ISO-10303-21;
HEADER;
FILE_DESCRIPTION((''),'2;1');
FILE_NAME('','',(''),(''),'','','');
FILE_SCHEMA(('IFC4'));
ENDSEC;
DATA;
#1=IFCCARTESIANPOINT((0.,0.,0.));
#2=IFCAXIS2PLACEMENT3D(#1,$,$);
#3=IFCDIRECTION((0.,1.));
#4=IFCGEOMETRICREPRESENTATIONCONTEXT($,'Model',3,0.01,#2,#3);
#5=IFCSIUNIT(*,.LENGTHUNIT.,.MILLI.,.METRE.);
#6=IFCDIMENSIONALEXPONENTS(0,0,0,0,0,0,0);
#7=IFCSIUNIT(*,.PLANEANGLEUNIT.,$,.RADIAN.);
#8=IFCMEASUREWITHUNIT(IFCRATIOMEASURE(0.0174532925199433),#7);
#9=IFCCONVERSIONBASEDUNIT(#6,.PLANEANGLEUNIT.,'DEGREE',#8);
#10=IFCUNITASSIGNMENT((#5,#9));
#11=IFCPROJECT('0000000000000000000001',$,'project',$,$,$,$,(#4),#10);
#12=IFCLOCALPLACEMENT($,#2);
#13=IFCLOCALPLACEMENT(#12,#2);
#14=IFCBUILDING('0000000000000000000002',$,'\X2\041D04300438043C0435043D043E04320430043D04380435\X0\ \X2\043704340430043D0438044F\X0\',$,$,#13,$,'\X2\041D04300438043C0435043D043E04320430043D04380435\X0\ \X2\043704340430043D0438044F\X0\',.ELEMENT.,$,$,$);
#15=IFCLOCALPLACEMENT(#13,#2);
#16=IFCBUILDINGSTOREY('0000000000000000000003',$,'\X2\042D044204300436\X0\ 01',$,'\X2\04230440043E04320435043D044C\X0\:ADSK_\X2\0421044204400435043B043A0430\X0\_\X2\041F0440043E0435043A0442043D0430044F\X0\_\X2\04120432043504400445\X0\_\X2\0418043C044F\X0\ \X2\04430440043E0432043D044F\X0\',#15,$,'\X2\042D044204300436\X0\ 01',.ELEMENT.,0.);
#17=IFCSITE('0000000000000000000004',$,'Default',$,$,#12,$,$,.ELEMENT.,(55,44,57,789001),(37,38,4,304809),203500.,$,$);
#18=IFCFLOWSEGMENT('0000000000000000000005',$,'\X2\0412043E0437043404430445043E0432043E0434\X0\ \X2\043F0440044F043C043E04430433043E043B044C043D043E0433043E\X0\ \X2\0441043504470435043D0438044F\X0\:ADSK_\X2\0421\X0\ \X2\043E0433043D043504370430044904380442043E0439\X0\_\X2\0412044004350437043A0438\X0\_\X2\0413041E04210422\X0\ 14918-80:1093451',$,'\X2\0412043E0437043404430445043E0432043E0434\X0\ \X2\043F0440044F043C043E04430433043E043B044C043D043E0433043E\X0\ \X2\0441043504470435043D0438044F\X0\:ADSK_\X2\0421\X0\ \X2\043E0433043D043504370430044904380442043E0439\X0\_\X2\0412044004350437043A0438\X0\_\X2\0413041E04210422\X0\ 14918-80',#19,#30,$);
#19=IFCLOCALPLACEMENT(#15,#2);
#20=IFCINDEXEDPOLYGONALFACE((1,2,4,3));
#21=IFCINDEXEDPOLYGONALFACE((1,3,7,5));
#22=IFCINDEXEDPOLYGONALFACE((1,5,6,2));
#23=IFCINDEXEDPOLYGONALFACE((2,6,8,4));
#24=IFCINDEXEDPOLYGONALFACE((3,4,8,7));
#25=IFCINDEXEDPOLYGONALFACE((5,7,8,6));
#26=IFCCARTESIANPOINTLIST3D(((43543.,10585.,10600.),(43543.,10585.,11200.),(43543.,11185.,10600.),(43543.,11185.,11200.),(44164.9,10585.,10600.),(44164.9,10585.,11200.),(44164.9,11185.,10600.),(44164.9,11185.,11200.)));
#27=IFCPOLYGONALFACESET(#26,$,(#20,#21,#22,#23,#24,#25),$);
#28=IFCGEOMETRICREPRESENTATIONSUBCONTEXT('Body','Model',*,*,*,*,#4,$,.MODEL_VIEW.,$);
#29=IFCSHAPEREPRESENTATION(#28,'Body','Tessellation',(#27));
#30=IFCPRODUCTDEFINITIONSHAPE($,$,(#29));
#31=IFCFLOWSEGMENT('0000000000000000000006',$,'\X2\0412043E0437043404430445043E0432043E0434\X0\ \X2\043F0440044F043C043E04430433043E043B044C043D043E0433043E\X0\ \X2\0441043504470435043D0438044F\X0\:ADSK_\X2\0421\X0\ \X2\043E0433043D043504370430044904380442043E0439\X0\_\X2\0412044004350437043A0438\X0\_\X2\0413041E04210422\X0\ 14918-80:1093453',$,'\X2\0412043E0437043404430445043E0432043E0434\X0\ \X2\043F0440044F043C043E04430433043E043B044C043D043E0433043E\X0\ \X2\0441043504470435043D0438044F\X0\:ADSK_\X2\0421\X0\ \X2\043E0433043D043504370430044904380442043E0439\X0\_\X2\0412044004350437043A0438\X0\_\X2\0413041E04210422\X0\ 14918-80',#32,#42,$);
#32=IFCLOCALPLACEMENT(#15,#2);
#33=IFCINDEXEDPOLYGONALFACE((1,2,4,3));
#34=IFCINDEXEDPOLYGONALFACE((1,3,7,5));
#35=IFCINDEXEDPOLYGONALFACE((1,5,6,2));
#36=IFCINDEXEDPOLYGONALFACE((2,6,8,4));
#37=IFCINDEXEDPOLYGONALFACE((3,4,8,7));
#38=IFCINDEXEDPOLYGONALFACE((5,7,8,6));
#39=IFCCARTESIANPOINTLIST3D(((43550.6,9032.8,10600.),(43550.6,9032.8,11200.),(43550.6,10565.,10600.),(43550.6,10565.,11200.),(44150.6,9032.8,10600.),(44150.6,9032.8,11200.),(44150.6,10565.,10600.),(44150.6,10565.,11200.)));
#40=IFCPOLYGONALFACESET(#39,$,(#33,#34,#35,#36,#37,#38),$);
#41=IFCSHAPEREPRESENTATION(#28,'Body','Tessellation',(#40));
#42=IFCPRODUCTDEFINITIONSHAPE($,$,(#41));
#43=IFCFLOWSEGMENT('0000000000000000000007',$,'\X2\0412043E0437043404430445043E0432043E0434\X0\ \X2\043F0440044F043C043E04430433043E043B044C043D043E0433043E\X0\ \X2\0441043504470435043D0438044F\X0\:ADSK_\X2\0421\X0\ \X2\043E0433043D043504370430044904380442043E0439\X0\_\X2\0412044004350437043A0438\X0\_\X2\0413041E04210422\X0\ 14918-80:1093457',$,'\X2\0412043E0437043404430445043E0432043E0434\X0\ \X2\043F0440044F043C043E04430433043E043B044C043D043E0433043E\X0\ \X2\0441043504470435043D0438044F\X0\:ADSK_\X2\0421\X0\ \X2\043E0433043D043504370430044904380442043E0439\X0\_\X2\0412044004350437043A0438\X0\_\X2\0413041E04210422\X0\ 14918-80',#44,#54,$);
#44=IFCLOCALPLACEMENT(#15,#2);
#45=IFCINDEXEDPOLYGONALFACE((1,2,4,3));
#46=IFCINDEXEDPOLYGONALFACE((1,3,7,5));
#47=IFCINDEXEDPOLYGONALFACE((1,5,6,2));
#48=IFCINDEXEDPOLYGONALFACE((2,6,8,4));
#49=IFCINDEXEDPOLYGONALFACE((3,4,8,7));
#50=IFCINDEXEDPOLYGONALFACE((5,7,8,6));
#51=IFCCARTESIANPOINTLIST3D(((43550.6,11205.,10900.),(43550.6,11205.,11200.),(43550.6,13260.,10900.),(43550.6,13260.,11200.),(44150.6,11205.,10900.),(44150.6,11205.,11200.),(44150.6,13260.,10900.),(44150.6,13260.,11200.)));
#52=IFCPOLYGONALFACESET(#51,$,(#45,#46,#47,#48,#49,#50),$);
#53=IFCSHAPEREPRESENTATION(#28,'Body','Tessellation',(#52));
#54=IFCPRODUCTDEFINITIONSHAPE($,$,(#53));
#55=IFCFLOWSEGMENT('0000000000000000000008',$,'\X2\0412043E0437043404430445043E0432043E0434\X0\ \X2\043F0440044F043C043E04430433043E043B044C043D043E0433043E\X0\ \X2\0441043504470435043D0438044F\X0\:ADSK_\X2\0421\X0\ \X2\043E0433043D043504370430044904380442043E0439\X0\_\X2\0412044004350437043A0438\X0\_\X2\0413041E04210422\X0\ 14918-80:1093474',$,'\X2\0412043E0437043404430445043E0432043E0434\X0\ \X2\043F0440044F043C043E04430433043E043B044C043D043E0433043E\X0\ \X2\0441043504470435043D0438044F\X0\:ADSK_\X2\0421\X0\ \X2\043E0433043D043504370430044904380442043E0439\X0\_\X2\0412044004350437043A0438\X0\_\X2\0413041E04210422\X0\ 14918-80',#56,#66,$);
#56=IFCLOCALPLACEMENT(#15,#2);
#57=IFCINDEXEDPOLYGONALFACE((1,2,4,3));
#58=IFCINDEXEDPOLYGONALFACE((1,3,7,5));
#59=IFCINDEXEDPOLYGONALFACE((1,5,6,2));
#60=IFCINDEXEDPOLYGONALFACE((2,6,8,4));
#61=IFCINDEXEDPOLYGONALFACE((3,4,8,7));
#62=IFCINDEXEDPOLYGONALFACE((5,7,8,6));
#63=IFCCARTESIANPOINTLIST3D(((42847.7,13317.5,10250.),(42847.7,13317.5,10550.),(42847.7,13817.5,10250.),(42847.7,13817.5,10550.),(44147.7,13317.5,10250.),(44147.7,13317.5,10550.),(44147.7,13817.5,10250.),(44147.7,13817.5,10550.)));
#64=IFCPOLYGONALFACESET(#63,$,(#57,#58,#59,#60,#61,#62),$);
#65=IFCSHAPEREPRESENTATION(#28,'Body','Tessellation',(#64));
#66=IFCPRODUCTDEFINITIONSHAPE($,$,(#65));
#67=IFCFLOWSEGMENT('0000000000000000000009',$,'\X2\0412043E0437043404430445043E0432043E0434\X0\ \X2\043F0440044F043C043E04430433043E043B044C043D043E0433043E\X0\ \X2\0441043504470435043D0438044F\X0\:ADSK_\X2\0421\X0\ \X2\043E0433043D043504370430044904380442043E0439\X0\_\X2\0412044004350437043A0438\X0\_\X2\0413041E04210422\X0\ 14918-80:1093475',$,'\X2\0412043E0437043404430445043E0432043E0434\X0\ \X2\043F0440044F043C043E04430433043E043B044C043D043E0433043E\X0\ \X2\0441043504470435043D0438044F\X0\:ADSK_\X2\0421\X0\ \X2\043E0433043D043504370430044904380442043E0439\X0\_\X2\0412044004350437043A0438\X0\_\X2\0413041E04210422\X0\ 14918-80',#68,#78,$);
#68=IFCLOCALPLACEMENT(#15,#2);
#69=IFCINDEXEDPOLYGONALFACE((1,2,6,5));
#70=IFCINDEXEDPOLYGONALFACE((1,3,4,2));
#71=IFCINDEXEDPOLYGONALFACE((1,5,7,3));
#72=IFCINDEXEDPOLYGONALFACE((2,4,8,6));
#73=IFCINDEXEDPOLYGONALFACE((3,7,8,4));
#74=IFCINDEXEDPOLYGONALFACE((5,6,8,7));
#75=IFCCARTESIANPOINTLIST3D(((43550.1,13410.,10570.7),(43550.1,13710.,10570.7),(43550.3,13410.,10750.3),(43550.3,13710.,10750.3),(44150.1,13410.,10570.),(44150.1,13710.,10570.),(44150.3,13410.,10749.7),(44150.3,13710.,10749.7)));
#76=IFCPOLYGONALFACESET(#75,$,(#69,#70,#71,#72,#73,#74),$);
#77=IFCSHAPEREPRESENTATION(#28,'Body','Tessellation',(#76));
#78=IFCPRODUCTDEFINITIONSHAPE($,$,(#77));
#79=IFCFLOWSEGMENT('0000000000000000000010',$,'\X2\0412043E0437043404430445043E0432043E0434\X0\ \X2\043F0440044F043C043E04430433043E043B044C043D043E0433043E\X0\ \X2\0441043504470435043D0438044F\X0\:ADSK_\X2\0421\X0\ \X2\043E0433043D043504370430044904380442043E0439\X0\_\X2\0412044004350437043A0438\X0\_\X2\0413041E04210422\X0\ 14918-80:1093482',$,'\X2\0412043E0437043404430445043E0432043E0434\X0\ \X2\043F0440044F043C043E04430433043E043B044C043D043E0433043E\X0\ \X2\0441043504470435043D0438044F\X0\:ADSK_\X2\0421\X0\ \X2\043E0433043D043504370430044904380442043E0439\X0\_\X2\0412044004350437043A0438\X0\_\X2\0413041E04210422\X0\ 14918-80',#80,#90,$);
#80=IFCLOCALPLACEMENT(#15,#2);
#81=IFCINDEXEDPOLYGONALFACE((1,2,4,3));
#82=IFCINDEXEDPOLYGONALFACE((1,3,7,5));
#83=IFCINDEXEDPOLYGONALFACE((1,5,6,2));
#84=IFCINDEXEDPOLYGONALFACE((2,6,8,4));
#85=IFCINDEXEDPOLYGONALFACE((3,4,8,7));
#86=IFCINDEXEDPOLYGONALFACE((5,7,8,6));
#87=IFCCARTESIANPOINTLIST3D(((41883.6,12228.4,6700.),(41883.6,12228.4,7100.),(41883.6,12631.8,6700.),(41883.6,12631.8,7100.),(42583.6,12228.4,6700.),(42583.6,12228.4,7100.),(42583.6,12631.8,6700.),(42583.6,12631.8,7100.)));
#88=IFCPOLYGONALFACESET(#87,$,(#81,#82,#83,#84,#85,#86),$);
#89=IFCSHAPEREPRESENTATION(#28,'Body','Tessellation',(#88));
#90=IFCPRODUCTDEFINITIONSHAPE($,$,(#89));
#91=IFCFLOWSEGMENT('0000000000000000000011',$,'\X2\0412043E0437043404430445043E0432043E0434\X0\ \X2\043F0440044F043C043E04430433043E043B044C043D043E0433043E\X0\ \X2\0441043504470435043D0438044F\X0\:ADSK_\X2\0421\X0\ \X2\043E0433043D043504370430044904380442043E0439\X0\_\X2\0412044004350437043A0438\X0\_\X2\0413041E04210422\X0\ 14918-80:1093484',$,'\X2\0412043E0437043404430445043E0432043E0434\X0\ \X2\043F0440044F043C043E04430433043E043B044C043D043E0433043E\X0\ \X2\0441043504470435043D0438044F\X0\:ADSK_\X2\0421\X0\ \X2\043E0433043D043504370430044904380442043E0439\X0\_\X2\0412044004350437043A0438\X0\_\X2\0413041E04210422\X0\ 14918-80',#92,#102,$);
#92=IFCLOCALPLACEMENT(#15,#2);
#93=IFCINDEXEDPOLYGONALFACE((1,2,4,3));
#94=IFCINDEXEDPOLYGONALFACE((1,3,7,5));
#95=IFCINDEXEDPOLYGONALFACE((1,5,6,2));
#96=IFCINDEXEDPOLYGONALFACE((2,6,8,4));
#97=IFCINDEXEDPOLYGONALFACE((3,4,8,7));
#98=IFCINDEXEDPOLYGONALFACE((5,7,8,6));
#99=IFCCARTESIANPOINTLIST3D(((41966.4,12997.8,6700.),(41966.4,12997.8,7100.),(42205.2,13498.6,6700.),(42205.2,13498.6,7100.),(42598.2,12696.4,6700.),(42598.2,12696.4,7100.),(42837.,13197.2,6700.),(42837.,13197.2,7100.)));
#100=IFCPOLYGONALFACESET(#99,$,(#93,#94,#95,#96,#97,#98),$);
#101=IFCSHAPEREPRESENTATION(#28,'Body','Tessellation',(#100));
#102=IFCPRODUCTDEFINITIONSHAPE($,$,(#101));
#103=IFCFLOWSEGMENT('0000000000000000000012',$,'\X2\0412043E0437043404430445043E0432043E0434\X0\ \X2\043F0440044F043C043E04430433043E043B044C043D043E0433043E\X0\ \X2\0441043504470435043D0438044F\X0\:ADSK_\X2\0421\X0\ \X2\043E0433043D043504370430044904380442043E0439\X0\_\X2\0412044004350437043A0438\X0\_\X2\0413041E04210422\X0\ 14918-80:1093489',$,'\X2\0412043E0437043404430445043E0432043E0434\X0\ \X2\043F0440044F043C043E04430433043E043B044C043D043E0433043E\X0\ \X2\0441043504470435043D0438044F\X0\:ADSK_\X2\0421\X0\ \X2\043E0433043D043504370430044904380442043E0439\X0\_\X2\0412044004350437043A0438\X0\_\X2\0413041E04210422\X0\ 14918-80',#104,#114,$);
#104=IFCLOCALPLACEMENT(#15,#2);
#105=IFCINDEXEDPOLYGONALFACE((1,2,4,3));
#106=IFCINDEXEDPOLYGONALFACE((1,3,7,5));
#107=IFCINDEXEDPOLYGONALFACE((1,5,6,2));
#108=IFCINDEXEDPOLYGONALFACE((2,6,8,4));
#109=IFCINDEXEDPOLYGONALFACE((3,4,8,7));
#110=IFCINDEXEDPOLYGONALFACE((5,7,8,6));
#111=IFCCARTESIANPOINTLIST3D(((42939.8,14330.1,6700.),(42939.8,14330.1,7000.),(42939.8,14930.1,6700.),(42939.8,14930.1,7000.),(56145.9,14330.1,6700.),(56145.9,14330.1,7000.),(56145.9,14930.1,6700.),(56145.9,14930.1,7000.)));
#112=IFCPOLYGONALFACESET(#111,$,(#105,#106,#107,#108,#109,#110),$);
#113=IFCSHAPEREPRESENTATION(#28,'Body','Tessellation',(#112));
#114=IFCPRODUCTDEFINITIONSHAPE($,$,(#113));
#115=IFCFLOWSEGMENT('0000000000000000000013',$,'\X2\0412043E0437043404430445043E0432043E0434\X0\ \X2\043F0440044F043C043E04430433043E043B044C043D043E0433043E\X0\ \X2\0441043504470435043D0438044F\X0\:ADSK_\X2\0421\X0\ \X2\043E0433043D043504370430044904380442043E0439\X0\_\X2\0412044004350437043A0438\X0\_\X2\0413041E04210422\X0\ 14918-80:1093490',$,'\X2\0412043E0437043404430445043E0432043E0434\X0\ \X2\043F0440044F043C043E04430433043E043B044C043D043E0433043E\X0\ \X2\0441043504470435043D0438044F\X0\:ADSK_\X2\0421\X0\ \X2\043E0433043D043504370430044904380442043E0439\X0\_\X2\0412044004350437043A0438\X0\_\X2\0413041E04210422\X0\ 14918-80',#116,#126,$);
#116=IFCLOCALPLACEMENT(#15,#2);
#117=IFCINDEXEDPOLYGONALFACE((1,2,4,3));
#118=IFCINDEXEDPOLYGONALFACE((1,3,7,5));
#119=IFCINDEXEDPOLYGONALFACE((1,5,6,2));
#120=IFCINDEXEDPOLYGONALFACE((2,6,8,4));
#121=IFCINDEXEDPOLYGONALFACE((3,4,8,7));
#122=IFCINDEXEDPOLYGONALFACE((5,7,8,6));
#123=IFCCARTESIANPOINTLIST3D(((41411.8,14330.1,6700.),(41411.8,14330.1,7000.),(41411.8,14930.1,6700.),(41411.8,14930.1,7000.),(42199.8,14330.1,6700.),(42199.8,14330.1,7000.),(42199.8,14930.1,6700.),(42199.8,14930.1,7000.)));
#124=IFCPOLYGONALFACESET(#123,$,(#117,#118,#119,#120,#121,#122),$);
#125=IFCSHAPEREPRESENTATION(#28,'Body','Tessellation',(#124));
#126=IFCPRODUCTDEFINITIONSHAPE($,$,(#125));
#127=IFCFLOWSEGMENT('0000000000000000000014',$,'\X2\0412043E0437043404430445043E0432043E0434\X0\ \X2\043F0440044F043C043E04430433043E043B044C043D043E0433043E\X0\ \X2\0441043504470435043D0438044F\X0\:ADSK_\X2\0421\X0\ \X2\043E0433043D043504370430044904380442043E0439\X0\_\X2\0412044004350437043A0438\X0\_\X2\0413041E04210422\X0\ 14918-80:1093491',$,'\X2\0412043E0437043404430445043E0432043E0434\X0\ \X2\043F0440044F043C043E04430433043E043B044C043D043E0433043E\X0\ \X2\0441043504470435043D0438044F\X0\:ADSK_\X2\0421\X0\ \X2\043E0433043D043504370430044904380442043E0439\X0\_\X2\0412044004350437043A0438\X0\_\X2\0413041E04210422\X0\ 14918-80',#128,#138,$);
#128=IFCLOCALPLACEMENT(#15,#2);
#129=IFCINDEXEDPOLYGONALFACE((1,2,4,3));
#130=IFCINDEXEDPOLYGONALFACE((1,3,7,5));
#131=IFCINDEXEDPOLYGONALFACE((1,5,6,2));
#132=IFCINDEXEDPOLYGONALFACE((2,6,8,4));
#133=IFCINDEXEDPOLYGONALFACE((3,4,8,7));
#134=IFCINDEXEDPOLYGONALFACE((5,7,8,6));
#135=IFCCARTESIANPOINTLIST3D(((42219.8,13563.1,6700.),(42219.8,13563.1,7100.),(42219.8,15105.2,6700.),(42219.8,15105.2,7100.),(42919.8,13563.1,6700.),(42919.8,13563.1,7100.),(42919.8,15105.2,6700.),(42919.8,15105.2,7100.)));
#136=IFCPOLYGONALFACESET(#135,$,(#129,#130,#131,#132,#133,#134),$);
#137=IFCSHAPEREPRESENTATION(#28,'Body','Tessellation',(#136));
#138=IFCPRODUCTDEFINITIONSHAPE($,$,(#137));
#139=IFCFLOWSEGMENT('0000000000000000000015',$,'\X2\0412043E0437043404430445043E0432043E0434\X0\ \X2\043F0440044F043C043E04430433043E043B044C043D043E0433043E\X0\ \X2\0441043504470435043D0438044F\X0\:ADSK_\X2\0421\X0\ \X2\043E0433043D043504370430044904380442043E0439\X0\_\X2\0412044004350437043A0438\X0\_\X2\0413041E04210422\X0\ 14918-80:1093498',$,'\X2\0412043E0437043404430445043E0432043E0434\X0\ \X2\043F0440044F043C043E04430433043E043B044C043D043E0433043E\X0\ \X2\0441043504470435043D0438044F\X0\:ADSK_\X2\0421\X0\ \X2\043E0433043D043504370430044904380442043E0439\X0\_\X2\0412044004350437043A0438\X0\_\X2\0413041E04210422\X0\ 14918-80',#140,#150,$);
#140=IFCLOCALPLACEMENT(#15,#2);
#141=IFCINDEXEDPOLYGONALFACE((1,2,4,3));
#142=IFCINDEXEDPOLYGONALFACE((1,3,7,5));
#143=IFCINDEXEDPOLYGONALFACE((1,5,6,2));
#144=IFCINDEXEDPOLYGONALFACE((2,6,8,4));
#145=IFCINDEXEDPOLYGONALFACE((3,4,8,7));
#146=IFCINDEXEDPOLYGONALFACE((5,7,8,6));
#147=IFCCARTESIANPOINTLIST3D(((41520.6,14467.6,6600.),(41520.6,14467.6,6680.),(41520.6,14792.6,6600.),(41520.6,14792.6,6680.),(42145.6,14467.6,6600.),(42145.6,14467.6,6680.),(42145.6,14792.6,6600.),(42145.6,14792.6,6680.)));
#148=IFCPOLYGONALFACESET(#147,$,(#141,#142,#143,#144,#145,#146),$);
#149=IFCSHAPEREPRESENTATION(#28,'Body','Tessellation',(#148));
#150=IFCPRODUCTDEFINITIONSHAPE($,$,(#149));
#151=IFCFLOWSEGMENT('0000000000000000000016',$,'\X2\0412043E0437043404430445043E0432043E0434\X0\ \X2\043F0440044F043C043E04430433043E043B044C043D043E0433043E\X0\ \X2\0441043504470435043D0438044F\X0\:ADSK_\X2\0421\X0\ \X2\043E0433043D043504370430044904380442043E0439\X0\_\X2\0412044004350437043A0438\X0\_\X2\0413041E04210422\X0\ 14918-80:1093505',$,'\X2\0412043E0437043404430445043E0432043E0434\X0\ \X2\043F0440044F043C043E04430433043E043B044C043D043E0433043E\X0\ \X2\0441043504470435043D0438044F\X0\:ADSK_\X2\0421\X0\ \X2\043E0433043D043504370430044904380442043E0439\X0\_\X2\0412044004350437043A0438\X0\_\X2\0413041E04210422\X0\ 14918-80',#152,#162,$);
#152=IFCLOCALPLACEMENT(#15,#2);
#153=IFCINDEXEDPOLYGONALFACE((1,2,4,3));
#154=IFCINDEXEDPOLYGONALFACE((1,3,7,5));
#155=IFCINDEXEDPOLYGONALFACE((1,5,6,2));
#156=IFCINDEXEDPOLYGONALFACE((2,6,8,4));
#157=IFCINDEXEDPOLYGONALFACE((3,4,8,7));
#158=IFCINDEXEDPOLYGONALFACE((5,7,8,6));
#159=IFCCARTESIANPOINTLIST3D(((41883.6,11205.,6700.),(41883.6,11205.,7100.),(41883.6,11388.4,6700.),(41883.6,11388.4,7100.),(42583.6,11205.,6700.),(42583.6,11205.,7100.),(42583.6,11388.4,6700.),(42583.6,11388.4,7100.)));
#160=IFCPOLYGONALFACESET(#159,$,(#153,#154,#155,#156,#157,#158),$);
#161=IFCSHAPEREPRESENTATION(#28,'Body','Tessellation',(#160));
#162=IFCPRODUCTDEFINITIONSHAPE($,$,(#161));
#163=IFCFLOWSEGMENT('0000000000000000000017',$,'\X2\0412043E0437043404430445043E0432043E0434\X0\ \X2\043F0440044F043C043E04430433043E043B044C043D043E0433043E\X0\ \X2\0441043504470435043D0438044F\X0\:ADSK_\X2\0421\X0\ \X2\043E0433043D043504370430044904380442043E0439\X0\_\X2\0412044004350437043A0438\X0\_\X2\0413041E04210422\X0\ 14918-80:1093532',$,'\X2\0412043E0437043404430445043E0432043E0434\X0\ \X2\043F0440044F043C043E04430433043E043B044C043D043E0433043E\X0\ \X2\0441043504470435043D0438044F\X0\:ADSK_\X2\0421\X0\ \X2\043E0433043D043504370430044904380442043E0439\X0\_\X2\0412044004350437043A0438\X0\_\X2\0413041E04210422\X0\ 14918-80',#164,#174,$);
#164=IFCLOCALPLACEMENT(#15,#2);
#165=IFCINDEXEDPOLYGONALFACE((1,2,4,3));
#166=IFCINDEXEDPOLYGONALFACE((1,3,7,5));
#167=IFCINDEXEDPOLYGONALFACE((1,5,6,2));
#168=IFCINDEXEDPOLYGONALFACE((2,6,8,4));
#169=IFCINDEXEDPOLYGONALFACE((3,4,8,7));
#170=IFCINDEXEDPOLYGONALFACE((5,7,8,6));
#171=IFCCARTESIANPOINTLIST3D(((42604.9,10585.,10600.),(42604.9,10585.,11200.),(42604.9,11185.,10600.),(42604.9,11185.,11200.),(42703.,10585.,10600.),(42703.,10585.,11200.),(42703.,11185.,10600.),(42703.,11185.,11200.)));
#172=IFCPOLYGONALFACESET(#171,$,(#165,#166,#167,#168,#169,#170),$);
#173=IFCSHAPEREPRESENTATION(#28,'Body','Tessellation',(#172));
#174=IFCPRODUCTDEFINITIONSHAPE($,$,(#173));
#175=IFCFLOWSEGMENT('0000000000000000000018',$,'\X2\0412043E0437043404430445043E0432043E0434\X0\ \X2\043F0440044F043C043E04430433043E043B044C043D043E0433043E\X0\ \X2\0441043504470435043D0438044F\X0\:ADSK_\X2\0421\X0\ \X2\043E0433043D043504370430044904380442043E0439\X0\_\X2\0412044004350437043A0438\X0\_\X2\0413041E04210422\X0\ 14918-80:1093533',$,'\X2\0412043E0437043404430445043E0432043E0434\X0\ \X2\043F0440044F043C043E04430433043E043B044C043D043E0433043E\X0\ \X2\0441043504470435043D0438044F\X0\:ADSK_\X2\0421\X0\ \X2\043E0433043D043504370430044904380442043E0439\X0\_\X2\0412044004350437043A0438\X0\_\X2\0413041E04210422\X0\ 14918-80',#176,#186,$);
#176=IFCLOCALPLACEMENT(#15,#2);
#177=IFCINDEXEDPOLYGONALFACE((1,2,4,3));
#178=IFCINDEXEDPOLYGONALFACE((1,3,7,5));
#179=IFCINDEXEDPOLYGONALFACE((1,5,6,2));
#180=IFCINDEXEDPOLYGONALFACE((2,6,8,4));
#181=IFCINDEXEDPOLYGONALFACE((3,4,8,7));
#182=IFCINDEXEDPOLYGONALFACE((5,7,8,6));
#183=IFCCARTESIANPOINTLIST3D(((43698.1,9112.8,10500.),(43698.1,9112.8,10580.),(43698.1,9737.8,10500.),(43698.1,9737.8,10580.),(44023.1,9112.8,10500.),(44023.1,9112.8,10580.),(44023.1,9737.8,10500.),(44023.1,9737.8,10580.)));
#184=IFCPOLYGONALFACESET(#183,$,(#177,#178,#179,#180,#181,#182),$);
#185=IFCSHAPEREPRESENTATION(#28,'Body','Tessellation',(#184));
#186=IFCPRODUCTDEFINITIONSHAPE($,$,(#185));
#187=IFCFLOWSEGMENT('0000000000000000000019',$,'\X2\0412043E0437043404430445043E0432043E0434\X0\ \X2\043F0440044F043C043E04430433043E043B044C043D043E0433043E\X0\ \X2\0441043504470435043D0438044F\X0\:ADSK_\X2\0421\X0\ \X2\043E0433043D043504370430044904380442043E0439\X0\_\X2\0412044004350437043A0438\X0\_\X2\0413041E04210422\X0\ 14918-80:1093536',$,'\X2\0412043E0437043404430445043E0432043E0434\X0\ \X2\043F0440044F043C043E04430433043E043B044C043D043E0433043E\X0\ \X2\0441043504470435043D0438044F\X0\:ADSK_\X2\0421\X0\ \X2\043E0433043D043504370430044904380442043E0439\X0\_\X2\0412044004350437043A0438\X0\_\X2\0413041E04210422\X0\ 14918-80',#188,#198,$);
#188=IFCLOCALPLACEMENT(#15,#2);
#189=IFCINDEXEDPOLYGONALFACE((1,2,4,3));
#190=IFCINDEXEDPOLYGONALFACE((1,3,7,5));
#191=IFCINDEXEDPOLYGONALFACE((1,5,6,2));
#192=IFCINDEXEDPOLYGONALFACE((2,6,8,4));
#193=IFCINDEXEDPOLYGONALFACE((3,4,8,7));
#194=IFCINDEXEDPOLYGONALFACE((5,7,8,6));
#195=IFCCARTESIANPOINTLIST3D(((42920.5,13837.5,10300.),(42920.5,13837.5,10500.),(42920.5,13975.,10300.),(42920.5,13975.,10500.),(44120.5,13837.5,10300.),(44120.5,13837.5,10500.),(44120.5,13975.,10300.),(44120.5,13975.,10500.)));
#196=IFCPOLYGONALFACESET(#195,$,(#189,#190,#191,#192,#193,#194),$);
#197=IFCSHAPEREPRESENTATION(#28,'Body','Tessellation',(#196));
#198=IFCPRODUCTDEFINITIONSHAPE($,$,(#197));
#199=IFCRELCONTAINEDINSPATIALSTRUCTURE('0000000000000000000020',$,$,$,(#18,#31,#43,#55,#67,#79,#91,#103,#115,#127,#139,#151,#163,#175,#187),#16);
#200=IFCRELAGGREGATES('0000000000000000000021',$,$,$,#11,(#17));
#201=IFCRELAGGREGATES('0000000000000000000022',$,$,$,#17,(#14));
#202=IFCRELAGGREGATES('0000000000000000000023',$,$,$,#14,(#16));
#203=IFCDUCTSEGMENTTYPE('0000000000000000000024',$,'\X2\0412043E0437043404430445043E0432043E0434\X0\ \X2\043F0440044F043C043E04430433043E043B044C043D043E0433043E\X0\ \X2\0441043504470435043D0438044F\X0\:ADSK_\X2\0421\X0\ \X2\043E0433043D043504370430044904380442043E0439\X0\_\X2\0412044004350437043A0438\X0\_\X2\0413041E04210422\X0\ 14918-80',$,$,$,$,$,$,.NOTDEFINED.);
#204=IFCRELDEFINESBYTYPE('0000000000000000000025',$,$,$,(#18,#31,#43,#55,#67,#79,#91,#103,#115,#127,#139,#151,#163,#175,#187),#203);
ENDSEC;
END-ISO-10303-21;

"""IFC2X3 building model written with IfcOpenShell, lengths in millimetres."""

from ifc_helpers import new_model, entity, si_unit, converted_unit, direction, frame, frame_2d, origin, origin_2d_with_axis, place, context, subcontext, project, spatial, rectangle, extrude, type_object, element, save


model = new_model("IFC2X3")

# Units and contexts
model_context = context("Model", 3, precision=0.01, world=origin(), true_north=direction((0.0, 1.0)))
body_context = subcontext(model_context, "Body", "Model", "MODEL_VIEW")
ifc_project = project(units=[si_unit("LENGTHUNIT", "METRE", prefix="MILLI"), converted_unit("PLANEANGLEUNIT", "DEGREE", entity("IfcRatioMeasure", 0.0174532925199433), si_unit("PLANEANGLEUNIT", "RADIAN"), dimensions=[0, 0, 0, 0, 0, 0, 0])], contexts=[model_context])

# Site, building, storey
site_placement = place(None, frame((0.0, 0.0, 0.0)))
site = spatial("IfcSite", under=ifc_project, at=site_placement, Name="Default", CompositionType="ELEMENT", RefLatitude=(55, 44, 57, 789001), RefLongitude=(37, 38, 4, 304809), RefElevation=203500.0)
building_placement = place(site_placement, origin())
building = spatial("IfcBuilding", under=site, at=building_placement, Name="Наименование здания", LongName="Наименование здания", CompositionType="ELEMENT")
storey_placement = place(building_placement, origin())
storey = spatial("IfcBuildingStorey", under=building, at=storey_placement, Name="Этаж 01", ObjectType="Уровень:ADSK_Стрелка_Проектная_Вверх_Имя уровня", LongName="Этаж 01", CompositionType="ELEMENT", Elevation=0.0)

# Flow segments
duct_segment_type = type_object("IfcDuctSegmentType", Name="Воздуховод прямоугольного сечения:ADSK_С огнезащитой_Врезки_ГОСТ 14918-80", PredefinedType="NOTDEFINED")
flow_segment_1_placement = place(storey_placement, frame((43543.0, 10585.0, 10600.0)))
element("IfcFlowSegment", 1, at=flow_segment_1_placement, inside=storey, type_object=duct_segment_type, Name="Воздуховод прямоугольного сечения:ADSK_С огнезащитой_Врезки_ГОСТ 14918-80:1093451", ObjectType="Воздуховод прямоугольного сечения:ADSK_С огнезащитой_Врезки_ГОСТ 14918-80", context=body_context, shape_type="SweptSolid", body=[
    extrude(rectangle(XDim=621.9, YDim=600.0, at=frame_2d((0.0, 0.0), x_axis=(1.0, 0.0))), frame((310.9, 300.0, 0.0)), (0.0, 0.0, 1.0), 600.0),
])
flow_segment_2_placement = place(storey_placement, frame((43550.6, 9032.8, 10600.0)))
element("IfcFlowSegment", 2, at=flow_segment_2_placement, inside=storey, type_object=duct_segment_type, Name="Воздуховод прямоугольного сечения:ADSK_С огнезащитой_Врезки_ГОСТ 14918-80:1093453", ObjectType="Воздуховод прямоугольного сечения:ADSK_С огнезащитой_Врезки_ГОСТ 14918-80", context=body_context, shape_type="SweptSolid", body=[
    extrude(rectangle(XDim=1532.2, YDim=600.0, at=frame_2d((0.0, 0.0), x_axis=(1.0, 0.0))), frame((300.0, 766.1, 0.0), z_axis=(0.0, 0.0, 1.0), x_axis=(0.0, 1.0, 0.0)), (0.0, 0.0, 1.0), 600.0),
])
flow_segment_3_placement = place(storey_placement, frame((43550.6, 11205.0, 10900.0)))
element("IfcFlowSegment", 3, at=flow_segment_3_placement, inside=storey, type_object=duct_segment_type, Name="Воздуховод прямоугольного сечения:ADSK_С огнезащитой_Врезки_ГОСТ 14918-80:1093457", ObjectType="Воздуховод прямоугольного сечения:ADSK_С огнезащитой_Врезки_ГОСТ 14918-80", context=body_context, shape_type="SweptSolid", body=[
    extrude(rectangle(XDim=2055.0, YDim=600.0, at=frame_2d((0.0, 0.0), x_axis=(1.0, 0.0))), frame((300.0, 1027.5, 0.0), z_axis=(0.0, 0.0, 1.0), x_axis=(0.0, 1.0, 0.0)), (0.0, 0.0, 1.0), 300.0),
])
flow_segment_4_placement = place(storey_placement, frame((42847.7, 13317.5, 10250.0)))
element("IfcFlowSegment", 4, at=flow_segment_4_placement, inside=storey, type_object=duct_segment_type, Name="Воздуховод прямоугольного сечения:ADSK_С огнезащитой_Врезки_ГОСТ 14918-80:1093474", ObjectType="Воздуховод прямоугольного сечения:ADSK_С огнезащитой_Врезки_ГОСТ 14918-80", context=body_context, shape_type="SweptSolid", body=[
    extrude(rectangle(XDim=1300.0, YDim=500.0, at=frame_2d((0.0, 0.0), x_axis=(1.0, 0.0))), frame((650.0, 250.0, 0.0), z_axis=(0.0, 0.0, 1.0), x_axis=(-1.0, 0.0, 0.0)), (0.0, 0.0, 1.0), 300.0),
])
flow_segment_5_placement = place(storey_placement, frame((43550.1, 13410.0, 10570.0)))
element("IfcFlowSegment", 5, at=flow_segment_5_placement, inside=storey, type_object=duct_segment_type, Name="Воздуховод прямоугольного сечения:ADSK_С огнезащитой_Врезки_ГОСТ 14918-80:1093475", ObjectType="Воздуховод прямоугольного сечения:ADSK_С огнезащитой_Врезки_ГОСТ 14918-80", context=body_context, shape_type="SweptSolid", body=[
    extrude(rectangle(XDim=600.0, YDim=300.0, at=frame_2d((0.0, 0.0), x_axis=(1.0, 0.0))), frame((300.0, 150.0, 0.3), z_axis=(0.0011, 0.0, 0.999999), x_axis=(0.999999, 0.0, -0.0011)), (0.0, 0.0, 1.0), 179.7),
])
flow_segment_6_placement = place(storey_placement, frame((41883.6, 12228.4, 6700.0)))
element("IfcFlowSegment", 6, at=flow_segment_6_placement, inside=storey, type_object=duct_segment_type, Name="Воздуховод прямоугольного сечения:ADSK_С огнезащитой_Врезки_ГОСТ 14918-80:1093482", ObjectType="Воздуховод прямоугольного сечения:ADSK_С огнезащитой_Врезки_ГОСТ 14918-80", context=body_context, shape_type="SweptSolid", body=[
    extrude(rectangle(XDim=403.4, YDim=700.0, at=frame_2d((0.0, 0.0), x_axis=(1.0, 0.0))), frame((350.0, 201.7, 0.0), z_axis=(0.0, 0.0, 1.0), x_axis=(0.0, 1.0, 0.0)), (0.0, 0.0, 1.0), 400.0),
])
flow_segment_7_placement = place(storey_placement, frame((41966.4, 12696.4, 6700.0)))
element("IfcFlowSegment", 7, at=flow_segment_7_placement, inside=storey, type_object=duct_segment_type, Name="Воздуховод прямоугольного сечения:ADSK_С огнезащитой_Врезки_ГОСТ 14918-80:1093484", ObjectType="Воздуховод прямоугольного сечения:ADSK_С огнезащитой_Врезки_ГОСТ 14918-80", context=body_context, shape_type="SweptSolid", body=[
    extrude(rectangle(XDim=554.8, YDim=700.0, at=frame_2d((0.0, 0.0), x_axis=(1.0, 0.0))), frame((435.3, 401.1, 0.0), z_axis=(0.0, 0.0, 1.0), x_axis=(0.430524, 0.902579, 0.0)), (0.0, 0.0, 1.0), 400.0),
])
flow_segment_8_placement = place(storey_placement, frame((42939.8, 14330.1, 6700.0)))
element("IfcFlowSegment", 8, at=flow_segment_8_placement, inside=storey, type_object=duct_segment_type, Name="Воздуховод прямоугольного сечения:ADSK_С огнезащитой_Врезки_ГОСТ 14918-80:1093489", ObjectType="Воздуховод прямоугольного сечения:ADSK_С огнезащитой_Врезки_ГОСТ 14918-80", context=body_context, shape_type="SweptSolid", body=[
    extrude(rectangle(XDim=13206.1, YDim=600.0, at=frame_2d((0.0, 0.0), x_axis=(1.0, 0.0))), frame((6603.0, 300.0, 0.0), z_axis=(0.0, 0.0, 1.0), x_axis=(-1.0, 0.0, 0.0)), (0.0, 0.0, 1.0), 300.0),
])
flow_segment_9_placement = place(storey_placement, frame((41411.8, 14330.1, 6700.0)))
element("IfcFlowSegment", 9, at=flow_segment_9_placement, inside=storey, type_object=duct_segment_type, Name="Воздуховод прямоугольного сечения:ADSK_С огнезащитой_Врезки_ГОСТ 14918-80:1093490", ObjectType="Воздуховод прямоугольного сечения:ADSK_С огнезащитой_Врезки_ГОСТ 14918-80", context=body_context, shape_type="SweptSolid", body=[
    extrude(rectangle(XDim=788.1, YDim=600.0, at=origin_2d_with_axis()), frame((394.0, 300.0, 0.0)), (0.0, 0.0, 1.0), 300.0),
])
flow_segment_10_placement = place(storey_placement, frame((42219.8, 13563.1, 6700.0)))
element("IfcFlowSegment", 10, at=flow_segment_10_placement, inside=storey, type_object=duct_segment_type, Name="Воздуховод прямоугольного сечения:ADSK_С огнезащитой_Врезки_ГОСТ 14918-80:1093491", ObjectType="Воздуховод прямоугольного сечения:ADSK_С огнезащитой_Врезки_ГОСТ 14918-80", context=body_context, shape_type="SweptSolid", body=[
    extrude(rectangle(XDim=1542.1, YDim=700.0, at=frame_2d((0.0, 0.0), x_axis=(1.0, 0.0))), frame((350.0, 771.0, 0.0), z_axis=(0.0, 0.0, 1.0), x_axis=(0.0, 1.0, 0.0)), (0.0, 0.0, 1.0), 400.0),
])
flow_segment_11_placement = place(storey_placement, frame((41520.6, 14467.6, 6600.0)))
element("IfcFlowSegment", 11, at=flow_segment_11_placement, inside=storey, type_object=duct_segment_type, Name="Воздуховод прямоугольного сечения:ADSK_С огнезащитой_Врезки_ГОСТ 14918-80:1093498", ObjectType="Воздуховод прямоугольного сечения:ADSK_С огнезащитой_Врезки_ГОСТ 14918-80", context=body_context, shape_type="SweptSolid", body=[
    extrude(rectangle(XDim=625.0, YDim=325.0, at=origin_2d_with_axis()), frame((312.5, 162.5, 0.0), z_axis=(0.0, 0.0, 1.0), x_axis=(-1.0, 0.0, 0.0)), (0.0, 0.0, 1.0), 80.0),
])
flow_segment_12_placement = place(storey_placement, frame((41883.6, 11205.0, 6700.0)))
element("IfcFlowSegment", 12, at=flow_segment_12_placement, inside=storey, type_object=duct_segment_type, Name="Воздуховод прямоугольного сечения:ADSK_С огнезащитой_Врезки_ГОСТ 14918-80:1093505", ObjectType="Воздуховод прямоугольного сечения:ADSK_С огнезащитой_Врезки_ГОСТ 14918-80", context=body_context, shape_type="SweptSolid", body=[
    extrude(rectangle(XDim=183.4, YDim=700.0, at=frame_2d((0.0, 0.0), x_axis=(1.0, 0.0))), frame((350.0, 91.7, 0.0), z_axis=(0.0, 0.0, 1.0), x_axis=(0.0, 1.0, 0.0)), (0.0, 0.0, 1.0), 400.0),
])
flow_segment_13_placement = place(storey_placement, frame((42604.9, 10585.0, 10600.0)))
element("IfcFlowSegment", 13, at=flow_segment_13_placement, inside=storey, type_object=duct_segment_type, Name="Воздуховод прямоугольного сечения:ADSK_С огнезащитой_Врезки_ГОСТ 14918-80:1093532", ObjectType="Воздуховод прямоугольного сечения:ADSK_С огнезащитой_Врезки_ГОСТ 14918-80", context=body_context, shape_type="SweptSolid", body=[
    extrude(rectangle(XDim=98.1, YDim=600.0, at=frame_2d((0.0, 0.0), x_axis=(1.0, 0.0))), frame((49.1, 300.0, 0.0)), (0.0, 0.0, 1.0), 600.0),
])
flow_segment_14_placement = place(storey_placement, frame((43698.1, 9112.8, 10500.0)))
element("IfcFlowSegment", 14, at=flow_segment_14_placement, inside=storey, type_object=duct_segment_type, Name="Воздуховод прямоугольного сечения:ADSK_С огнезащитой_Врезки_ГОСТ 14918-80:1093533", ObjectType="Воздуховод прямоугольного сечения:ADSK_С огнезащитой_Врезки_ГОСТ 14918-80", context=body_context, shape_type="SweptSolid", body=[
    extrude(rectangle(XDim=325.0, YDim=625.0, at=frame_2d((0.0, 0.0), x_axis=(1.0, 0.0))), frame((162.5, 312.5, 0.0), z_axis=(0.0, 0.0, 1.0), x_axis=(-1.0, 0.0, 0.0)), (0.0, 0.0, 1.0), 80.0),
])
flow_segment_15_placement = place(storey_placement, frame((42920.5, 13837.5, 10300.0)))
element("IfcFlowSegment", 15, at=flow_segment_15_placement, inside=storey, type_object=duct_segment_type, Name="Воздуховод прямоугольного сечения:ADSK_С огнезащитой_Врезки_ГОСТ 14918-80:1093536", ObjectType="Воздуховод прямоугольного сечения:ADSK_С огнезащитой_Врезки_ГОСТ 14918-80", context=body_context, shape_type="SweptSolid", body=[
    extrude(rectangle(XDim=137.5, YDim=1200.0, at=frame_2d((0.0, 0.0), x_axis=(1.0, 0.0))), frame((600.0, 68.8, 0.0), z_axis=(0.0, 0.0, 1.0), x_axis=(0.0, -1.0, 0.0)), (0.0, 0.0, 1.0), 200.0),
])

save(model, "model.ifc")
